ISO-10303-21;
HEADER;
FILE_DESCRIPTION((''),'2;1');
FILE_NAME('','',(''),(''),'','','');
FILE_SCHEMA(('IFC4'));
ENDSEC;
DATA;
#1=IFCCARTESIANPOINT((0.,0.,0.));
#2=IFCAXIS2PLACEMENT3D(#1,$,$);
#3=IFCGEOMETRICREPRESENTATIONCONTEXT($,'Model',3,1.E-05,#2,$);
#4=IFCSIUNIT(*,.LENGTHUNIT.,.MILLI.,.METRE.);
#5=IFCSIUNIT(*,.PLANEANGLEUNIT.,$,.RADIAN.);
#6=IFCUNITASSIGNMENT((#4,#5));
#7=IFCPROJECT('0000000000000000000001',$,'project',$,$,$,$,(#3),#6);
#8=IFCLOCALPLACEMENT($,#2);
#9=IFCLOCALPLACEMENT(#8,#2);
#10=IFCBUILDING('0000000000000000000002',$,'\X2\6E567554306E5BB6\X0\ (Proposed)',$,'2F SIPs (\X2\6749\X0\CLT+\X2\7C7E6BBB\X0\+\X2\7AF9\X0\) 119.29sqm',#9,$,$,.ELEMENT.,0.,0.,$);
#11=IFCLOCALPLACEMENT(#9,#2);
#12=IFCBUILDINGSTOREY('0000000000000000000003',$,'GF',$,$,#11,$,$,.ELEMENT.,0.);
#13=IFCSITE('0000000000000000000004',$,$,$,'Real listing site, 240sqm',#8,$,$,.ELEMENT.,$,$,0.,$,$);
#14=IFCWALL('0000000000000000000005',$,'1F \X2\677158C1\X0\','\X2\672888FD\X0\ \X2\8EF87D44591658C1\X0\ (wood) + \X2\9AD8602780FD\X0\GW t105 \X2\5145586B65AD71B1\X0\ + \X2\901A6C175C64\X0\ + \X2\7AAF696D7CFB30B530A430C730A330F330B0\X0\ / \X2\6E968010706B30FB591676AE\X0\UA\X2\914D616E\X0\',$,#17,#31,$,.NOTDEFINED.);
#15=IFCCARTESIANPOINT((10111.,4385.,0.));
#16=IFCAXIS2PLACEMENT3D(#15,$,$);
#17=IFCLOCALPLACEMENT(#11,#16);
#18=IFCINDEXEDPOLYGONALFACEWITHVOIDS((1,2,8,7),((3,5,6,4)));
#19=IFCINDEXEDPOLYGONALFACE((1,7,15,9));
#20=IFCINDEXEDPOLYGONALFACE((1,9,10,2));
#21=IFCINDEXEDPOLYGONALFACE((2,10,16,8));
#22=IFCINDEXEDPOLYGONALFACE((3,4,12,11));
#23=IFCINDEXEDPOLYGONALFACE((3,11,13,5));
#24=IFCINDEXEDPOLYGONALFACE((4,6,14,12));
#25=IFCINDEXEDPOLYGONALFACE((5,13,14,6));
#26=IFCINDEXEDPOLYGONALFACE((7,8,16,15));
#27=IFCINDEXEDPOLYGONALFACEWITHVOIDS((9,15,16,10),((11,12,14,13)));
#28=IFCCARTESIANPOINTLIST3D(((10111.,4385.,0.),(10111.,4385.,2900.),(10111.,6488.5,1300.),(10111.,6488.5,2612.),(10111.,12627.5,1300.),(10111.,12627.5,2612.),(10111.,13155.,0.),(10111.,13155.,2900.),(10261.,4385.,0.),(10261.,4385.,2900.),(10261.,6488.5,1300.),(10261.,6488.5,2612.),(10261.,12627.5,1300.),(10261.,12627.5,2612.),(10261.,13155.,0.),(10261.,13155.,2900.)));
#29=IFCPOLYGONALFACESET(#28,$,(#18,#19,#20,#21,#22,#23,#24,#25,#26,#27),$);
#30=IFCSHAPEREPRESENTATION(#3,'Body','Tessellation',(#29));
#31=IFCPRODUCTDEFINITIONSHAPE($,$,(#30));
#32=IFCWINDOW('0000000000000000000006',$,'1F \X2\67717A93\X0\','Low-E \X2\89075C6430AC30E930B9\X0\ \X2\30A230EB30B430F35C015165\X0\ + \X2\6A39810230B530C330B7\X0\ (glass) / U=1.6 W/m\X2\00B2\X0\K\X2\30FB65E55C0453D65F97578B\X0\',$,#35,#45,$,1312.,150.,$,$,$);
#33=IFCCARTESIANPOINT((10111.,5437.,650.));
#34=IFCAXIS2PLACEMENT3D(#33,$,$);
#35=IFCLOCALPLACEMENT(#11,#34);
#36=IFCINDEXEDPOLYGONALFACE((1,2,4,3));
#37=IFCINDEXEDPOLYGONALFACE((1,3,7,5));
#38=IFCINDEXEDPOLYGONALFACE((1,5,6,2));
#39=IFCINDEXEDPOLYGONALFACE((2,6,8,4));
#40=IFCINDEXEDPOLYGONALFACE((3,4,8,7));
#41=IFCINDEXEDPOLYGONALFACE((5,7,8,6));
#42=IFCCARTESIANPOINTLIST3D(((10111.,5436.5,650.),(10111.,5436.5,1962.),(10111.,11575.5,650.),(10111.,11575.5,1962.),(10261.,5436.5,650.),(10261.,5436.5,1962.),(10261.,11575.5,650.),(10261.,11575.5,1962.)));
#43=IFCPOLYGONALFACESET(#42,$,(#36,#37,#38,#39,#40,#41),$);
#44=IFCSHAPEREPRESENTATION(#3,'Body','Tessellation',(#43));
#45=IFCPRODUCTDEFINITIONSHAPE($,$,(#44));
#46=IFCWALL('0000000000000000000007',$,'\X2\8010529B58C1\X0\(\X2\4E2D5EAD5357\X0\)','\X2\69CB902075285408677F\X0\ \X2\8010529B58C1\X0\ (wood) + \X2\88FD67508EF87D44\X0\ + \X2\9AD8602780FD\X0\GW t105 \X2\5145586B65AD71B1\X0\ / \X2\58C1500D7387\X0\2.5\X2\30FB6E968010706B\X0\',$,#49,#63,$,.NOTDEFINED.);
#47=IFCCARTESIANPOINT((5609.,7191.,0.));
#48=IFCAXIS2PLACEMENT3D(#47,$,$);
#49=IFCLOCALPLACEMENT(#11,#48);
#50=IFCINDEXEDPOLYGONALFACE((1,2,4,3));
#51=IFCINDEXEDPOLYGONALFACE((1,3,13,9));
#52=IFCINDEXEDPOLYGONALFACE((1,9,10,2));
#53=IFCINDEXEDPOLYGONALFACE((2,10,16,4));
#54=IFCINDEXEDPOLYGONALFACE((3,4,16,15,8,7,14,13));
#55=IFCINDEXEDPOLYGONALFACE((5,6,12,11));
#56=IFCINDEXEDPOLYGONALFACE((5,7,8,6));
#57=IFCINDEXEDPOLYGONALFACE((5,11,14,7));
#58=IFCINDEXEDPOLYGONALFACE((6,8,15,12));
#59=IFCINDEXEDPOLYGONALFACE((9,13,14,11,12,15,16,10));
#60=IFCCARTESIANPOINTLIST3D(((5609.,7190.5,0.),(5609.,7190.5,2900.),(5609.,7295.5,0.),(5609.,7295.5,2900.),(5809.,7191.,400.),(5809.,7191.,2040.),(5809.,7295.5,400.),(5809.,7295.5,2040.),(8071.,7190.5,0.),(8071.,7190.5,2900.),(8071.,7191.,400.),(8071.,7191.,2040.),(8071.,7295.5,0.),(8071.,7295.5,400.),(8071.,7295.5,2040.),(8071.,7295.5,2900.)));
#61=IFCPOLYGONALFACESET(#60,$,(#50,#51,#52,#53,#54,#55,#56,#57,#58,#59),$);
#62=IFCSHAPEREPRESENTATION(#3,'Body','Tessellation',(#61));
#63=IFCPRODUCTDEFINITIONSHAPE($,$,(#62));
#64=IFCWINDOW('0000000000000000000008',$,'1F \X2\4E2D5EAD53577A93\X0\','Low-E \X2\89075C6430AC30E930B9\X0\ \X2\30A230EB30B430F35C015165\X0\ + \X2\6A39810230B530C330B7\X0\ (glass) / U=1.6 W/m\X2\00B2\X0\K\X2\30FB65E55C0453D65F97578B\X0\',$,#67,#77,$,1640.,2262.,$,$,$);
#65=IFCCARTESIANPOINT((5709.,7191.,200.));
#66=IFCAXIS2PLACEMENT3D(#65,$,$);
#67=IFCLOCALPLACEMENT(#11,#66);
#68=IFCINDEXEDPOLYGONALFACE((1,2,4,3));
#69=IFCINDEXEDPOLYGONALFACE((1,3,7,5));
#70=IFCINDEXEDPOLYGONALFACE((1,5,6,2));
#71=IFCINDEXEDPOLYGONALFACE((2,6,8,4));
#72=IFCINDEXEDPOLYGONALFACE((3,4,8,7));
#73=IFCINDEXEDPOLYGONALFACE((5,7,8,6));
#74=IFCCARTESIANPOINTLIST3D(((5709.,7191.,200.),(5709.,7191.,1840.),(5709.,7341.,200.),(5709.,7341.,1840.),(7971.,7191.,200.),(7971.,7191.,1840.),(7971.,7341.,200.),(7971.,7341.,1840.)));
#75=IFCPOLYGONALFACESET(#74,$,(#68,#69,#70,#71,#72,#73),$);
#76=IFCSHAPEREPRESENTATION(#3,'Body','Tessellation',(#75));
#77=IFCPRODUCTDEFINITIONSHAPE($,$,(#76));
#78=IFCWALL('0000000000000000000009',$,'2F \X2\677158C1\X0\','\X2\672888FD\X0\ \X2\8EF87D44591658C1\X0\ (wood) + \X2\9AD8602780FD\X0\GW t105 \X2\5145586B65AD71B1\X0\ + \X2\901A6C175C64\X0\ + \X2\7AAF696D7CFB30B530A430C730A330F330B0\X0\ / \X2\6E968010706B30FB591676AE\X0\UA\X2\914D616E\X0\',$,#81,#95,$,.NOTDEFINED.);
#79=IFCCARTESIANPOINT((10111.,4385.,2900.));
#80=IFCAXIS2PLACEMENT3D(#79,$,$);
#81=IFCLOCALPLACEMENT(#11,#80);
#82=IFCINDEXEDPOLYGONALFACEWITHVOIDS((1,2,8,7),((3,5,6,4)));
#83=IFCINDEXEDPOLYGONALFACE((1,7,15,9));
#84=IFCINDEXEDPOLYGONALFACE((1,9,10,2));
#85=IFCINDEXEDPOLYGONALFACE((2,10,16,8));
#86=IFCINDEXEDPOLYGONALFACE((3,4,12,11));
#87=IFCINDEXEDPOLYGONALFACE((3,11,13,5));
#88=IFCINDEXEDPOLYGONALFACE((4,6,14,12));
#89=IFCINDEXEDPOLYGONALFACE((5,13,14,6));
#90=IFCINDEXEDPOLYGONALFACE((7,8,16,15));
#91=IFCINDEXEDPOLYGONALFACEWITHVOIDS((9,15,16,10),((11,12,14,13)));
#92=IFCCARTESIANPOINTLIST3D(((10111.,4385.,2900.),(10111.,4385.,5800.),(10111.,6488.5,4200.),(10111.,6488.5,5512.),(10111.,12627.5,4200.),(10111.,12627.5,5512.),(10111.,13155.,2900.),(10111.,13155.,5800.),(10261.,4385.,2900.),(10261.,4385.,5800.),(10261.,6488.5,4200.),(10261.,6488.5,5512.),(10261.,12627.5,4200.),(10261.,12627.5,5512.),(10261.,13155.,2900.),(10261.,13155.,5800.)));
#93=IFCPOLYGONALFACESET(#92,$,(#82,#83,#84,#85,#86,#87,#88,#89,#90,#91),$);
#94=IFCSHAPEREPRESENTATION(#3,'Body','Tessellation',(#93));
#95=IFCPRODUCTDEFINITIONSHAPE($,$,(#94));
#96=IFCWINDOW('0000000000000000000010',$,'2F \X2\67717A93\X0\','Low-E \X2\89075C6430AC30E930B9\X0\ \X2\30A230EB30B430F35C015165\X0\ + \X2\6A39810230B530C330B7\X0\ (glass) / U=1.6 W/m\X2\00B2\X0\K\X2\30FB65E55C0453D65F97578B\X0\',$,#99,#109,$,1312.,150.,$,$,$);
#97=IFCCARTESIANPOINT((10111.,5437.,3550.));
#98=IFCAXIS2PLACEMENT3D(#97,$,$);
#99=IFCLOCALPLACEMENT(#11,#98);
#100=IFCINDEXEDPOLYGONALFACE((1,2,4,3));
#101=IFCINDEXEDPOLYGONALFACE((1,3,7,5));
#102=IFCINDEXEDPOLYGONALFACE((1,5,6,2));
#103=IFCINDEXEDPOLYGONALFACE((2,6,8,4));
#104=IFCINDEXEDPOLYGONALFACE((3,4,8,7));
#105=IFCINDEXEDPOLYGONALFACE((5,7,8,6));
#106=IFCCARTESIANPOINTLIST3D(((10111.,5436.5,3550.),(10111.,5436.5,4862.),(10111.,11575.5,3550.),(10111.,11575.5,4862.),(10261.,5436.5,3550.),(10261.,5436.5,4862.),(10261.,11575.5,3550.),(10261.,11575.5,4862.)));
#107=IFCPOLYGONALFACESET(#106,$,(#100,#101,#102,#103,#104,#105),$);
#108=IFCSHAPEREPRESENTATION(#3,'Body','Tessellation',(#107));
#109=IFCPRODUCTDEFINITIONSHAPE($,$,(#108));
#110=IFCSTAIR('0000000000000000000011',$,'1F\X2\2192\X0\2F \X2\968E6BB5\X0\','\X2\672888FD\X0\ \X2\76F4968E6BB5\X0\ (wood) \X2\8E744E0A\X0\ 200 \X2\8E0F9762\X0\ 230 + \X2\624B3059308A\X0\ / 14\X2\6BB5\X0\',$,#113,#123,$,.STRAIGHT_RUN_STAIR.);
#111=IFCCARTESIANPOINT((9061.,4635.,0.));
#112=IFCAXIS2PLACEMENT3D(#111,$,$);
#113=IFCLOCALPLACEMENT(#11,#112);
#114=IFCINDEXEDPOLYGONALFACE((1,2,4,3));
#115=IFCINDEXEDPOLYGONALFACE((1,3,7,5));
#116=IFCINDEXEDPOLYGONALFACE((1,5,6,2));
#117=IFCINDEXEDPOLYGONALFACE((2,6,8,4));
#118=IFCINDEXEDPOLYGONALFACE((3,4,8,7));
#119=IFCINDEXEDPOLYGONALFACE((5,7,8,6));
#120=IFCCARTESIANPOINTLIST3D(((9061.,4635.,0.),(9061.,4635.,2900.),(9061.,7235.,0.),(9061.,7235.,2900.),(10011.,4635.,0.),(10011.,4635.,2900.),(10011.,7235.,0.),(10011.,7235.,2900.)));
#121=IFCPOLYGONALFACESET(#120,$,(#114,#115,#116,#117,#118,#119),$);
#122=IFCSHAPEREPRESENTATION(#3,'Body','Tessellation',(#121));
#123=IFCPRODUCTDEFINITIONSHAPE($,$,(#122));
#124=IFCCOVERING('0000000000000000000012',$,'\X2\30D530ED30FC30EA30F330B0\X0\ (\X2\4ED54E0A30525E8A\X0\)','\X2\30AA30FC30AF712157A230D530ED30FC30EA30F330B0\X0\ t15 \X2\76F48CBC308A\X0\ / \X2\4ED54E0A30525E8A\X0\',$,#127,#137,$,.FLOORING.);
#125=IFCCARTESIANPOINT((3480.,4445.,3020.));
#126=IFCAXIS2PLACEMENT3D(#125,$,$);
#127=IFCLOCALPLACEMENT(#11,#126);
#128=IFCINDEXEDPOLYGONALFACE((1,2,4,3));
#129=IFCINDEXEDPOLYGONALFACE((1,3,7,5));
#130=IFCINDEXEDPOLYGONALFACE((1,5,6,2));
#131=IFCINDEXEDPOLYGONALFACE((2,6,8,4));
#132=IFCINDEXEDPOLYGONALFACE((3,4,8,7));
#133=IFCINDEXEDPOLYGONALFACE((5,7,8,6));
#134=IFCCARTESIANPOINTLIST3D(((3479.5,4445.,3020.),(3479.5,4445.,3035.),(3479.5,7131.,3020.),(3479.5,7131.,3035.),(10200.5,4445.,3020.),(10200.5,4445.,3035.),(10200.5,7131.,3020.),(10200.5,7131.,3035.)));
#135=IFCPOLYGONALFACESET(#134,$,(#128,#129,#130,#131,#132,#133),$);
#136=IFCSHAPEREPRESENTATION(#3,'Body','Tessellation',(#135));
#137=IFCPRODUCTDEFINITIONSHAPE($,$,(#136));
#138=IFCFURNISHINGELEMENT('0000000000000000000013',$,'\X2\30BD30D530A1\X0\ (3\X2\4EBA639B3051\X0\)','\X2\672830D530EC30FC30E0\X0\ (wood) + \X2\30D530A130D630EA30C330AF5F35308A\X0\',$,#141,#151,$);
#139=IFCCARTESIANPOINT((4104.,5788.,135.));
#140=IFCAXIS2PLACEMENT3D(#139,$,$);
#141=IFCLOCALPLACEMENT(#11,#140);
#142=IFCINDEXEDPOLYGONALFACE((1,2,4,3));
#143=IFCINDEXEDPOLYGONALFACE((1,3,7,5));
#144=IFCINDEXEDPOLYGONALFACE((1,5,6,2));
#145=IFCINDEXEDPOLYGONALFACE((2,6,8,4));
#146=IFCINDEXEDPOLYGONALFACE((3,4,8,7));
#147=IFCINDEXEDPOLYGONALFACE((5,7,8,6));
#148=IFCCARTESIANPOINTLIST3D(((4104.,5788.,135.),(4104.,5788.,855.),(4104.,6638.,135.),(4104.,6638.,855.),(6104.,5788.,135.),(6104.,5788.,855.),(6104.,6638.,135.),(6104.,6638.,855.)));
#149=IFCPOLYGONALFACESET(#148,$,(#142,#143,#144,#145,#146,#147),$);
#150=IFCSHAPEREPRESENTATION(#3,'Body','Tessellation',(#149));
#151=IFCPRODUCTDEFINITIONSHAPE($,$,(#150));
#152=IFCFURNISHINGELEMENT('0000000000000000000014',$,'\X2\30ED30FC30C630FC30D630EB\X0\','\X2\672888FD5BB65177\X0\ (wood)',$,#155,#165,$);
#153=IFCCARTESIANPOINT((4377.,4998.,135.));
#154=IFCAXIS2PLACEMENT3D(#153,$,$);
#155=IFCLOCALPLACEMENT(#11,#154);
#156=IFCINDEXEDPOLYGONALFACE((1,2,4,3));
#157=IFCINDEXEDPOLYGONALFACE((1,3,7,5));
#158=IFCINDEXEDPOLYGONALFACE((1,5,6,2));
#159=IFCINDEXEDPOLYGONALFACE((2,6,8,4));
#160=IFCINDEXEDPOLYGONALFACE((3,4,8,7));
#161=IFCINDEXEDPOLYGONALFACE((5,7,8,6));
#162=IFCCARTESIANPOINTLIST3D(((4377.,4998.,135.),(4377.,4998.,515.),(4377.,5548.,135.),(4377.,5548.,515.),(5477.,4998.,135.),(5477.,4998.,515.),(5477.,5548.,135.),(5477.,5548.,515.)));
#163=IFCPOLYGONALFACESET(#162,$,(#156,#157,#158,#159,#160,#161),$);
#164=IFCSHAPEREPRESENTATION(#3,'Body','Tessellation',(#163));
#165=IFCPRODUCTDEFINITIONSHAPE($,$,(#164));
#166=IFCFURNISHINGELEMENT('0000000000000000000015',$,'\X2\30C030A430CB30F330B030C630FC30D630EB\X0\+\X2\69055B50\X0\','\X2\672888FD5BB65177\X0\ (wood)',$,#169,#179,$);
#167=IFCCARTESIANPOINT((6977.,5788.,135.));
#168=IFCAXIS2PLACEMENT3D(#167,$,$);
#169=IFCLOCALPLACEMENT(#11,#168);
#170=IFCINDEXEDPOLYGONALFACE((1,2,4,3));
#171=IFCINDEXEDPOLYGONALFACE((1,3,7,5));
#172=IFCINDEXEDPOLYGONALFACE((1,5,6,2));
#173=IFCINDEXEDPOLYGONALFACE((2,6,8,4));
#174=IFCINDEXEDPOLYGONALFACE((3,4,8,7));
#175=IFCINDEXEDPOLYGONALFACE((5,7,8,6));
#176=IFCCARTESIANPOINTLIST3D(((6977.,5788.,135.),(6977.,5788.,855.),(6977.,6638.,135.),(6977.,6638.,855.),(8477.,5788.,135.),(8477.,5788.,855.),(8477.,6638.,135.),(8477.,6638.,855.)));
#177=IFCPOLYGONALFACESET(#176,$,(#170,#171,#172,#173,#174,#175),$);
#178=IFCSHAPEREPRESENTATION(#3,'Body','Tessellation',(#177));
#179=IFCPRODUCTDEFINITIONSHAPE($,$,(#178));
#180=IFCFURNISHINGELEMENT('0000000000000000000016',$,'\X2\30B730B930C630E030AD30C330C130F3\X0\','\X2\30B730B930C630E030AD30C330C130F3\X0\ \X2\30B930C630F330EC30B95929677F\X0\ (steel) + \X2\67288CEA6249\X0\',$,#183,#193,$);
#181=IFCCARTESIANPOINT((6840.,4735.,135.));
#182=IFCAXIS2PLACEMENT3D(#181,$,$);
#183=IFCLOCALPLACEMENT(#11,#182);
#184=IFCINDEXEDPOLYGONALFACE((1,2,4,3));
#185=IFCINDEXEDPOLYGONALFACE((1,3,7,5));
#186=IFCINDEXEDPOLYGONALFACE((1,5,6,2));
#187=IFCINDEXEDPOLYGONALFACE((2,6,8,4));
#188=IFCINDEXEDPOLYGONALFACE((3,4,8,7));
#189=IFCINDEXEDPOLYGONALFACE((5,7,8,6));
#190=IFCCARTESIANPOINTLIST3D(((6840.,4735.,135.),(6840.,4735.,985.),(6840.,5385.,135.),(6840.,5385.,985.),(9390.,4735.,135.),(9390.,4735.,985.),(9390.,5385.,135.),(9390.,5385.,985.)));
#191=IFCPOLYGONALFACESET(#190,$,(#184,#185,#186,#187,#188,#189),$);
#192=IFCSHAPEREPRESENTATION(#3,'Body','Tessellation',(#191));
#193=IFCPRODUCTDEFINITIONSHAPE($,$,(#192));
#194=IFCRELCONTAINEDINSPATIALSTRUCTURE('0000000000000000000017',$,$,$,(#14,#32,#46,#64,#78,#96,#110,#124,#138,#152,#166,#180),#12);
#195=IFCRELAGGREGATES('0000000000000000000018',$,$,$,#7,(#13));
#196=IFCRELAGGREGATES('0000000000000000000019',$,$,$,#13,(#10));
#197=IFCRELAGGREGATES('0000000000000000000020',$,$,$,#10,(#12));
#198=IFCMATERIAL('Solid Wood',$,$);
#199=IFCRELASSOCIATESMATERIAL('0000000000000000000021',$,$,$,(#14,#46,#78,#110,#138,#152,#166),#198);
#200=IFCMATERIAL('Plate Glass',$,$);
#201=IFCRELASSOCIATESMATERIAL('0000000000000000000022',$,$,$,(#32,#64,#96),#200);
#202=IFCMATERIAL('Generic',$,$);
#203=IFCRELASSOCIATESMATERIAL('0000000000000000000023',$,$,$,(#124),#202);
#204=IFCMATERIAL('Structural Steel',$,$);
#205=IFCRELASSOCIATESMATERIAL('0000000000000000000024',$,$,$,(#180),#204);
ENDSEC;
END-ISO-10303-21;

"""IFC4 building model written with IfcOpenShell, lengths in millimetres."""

from ifc_helpers import new_model, si_unit, frame, frame_2d, origin, place, context, project, spatial, rectangle, extrude, material, element, fill, save


model = new_model("IFC4")

# Units and contexts
model_context = context("Model", 3, precision=1e-05, world=origin())
ifc_project = project(units=[si_unit("LENGTHUNIT", "METRE", prefix="MILLI"), si_unit("PLANEANGLEUNIT", "RADIAN")], contexts=[model_context])

# Site, building, storey
site_placement = place(None, origin())
site = spatial("IfcSite", under=ifc_project, at=site_placement, ObjectType="Real listing site, 240sqm", CompositionType="ELEMENT", RefElevation=0.0)
building_placement = place(site_placement, origin())
building = spatial("IfcBuilding", under=site, at=building_placement, Name="湖畔の家 (Proposed)", ObjectType="2F SIPs (杉CLT+籾殻+竹) 119.29sqm", CompositionType="ELEMENT", ElevationOfRefHeight=0.0, ElevationOfTerrain=0.0)
storey_placement = place(building_placement, origin())
storey = spatial("IfcBuildingStorey", under=building, at=storey_placement, Name="GF", CompositionType="ELEMENT", Elevation=0.0)

# Shared definitions
ifc_material_1 = material(Name="Solid Wood")

# Walls, openings, windows
wall_1_placement = place(storey_placement, frame((10111.0, 4385.0, 0.0)))
wall_1 = element("IfcWall", 1, at=wall_1_placement, inside=storey, material=ifc_material_1, Name="1F 東壁", Description="木製 軸組外壁 (wood) + 高性能GW t105 充填断熱 + 通気層 + 窯業系サイディング / 準耐火・外皮UA配慮", PredefinedType="NOTDEFINED", context=model_context, shape_type="SweptSolid", body=[
    extrude(rectangle(XDim=150.0, YDim=8770.0, at=frame_2d((75.0, 4385.0))), frame((10111.0, 4385.0, 0.0)), (0.0, 0.0, 1.0), 2900.0),
])
opening_1_placement = place(storey_placement, frame((10111.0, 5437.0, 650.0)))
opening_1 = element("IfcOpeningElement", 2, at=opening_1_placement, cuts=wall_1, PredefinedType="NOTDEFINED", context=model_context, shape_type="SweptSolid", body=[
    extrude(rectangle(XDim=150.0, YDim=6139.0, at=frame_2d((75.0, 3069.0))), frame((10111.0, 5437.0, 650.0)), (0.0, 0.0, 1.0), 1312.0),
])
ifc_material_2 = material(Name="Plate Glass")
window_1_placement = place(storey_placement, frame((10111.0, 5437.0, 650.0)))
window_1 = element("IfcWindow", 3, at=window_1_placement, inside=storey, material=ifc_material_2, Name="1F 東窓", Description="Low-E 複層ガラス アルゴン封入 + 樹脂サッシ (glass) / U=1.6 W/m²K・日射取得型", OverallHeight=1312.0, OverallWidth=150.0, context=model_context, shape_type="SweptSolid", body=[
    extrude(rectangle(XDim=150.0, YDim=6139.0, at=frame_2d((75.0, 3069.0))), frame((10111.0, 5437.0, 650.0)), (0.0, 0.0, 1.0), 1312.0),
])
fill(opening_1, window_1)
wall_2_placement = place(storey_placement, frame((5609.0, 7191.0, 0.0)))
wall_2 = element("IfcWall", 4, at=wall_2_placement, inside=storey, material=ifc_material_1, Name="耐力壁(中庭南)", Description="構造用合板 耐力壁 (wood) + 製材軸組 + 高性能GW t105 充填断熱 / 壁倍率2.5・準耐火", PredefinedType="NOTDEFINED", context=model_context, shape_type="SweptSolid", body=[
    extrude(rectangle(XDim=2462.0, YDim=105.0, at=frame_2d((1231.0, 52.0))), frame((5609.0, 7191.0, 0.0)), (0.0, 0.0, 1.0), 2900.0),
])
opening_2_placement = place(storey_placement, frame((5709.0, 7191.0, 200.0)))
opening_2 = element("IfcOpeningElement", 5, at=opening_2_placement, cuts=wall_2, PredefinedType="NOTDEFINED", context=model_context, shape_type="SweptSolid", body=[
    extrude(rectangle(XDim=2262.0, YDim=150.0, at=frame_2d((1131.0, 75.0))), frame((5709.0, 7191.0, 200.0)), (0.0, 0.0, 1.0), 1640.0),
])
window_2_placement = place(storey_placement, frame((5709.0, 7191.0, 200.0)))
window_2 = element("IfcWindow", 6, at=window_2_placement, inside=storey, material=ifc_material_2, Name="1F 中庭南窓", Description="Low-E 複層ガラス アルゴン封入 + 樹脂サッシ (glass) / U=1.6 W/m²K・日射取得型", OverallHeight=1640.0, OverallWidth=2262.0, context=model_context, shape_type="SweptSolid", body=[
    extrude(rectangle(XDim=2262.0, YDim=150.0, at=frame_2d((1131.0, 75.0))), frame((5709.0, 7191.0, 200.0)), (0.0, 0.0, 1.0), 1640.0),
])
fill(opening_2, window_2)

# Wall, opening, window
wall_3_placement = place(storey_placement, frame((10111.0, 4385.0, 2900.0)))
wall_3 = element("IfcWall", 7, at=wall_3_placement, inside=storey, material=ifc_material_1, Name="2F 東壁", Description="木製 軸組外壁 (wood) + 高性能GW t105 充填断熱 + 通気層 + 窯業系サイディング / 準耐火・外皮UA配慮", PredefinedType="NOTDEFINED", context=model_context, shape_type="SweptSolid", body=[
    extrude(rectangle(XDim=150.0, YDim=8770.0, at=frame_2d((75.0, 4385.0))), frame((10111.0, 4385.0, 2900.0)), (0.0, 0.0, 1.0), 2900.0),
])
opening_3_placement = place(storey_placement, frame((10111.0, 5437.0, 3550.0)))
opening_3 = element("IfcOpeningElement", 8, at=opening_3_placement, cuts=wall_3, PredefinedType="NOTDEFINED", context=model_context, shape_type="SweptSolid", body=[
    extrude(rectangle(XDim=150.0, YDim=6139.0, at=frame_2d((75.0, 3069.0))), frame((10111.0, 5437.0, 3550.0)), (0.0, 0.0, 1.0), 1312.0),
])
window_3_placement = place(storey_placement, frame((10111.0, 5437.0, 3550.0)))
window_3 = element("IfcWindow", 9, at=window_3_placement, inside=storey, material=ifc_material_2, Name="2F 東窓", Description="Low-E 複層ガラス アルゴン封入 + 樹脂サッシ (glass) / U=1.6 W/m²K・日射取得型", OverallHeight=1312.0, OverallWidth=150.0, context=model_context, shape_type="SweptSolid", body=[
    extrude(rectangle(XDim=150.0, YDim=6139.0, at=frame_2d((75.0, 3069.0))), frame((10111.0, 5437.0, 3550.0)), (0.0, 0.0, 1.0), 1312.0),
])
fill(opening_3, window_3)

# Stair
stair_placement = place(storey_placement, frame((9061.0, 4635.0, 0.0)))
element("IfcStair", 10, at=stair_placement, inside=storey, material=ifc_material_1, Name="1F→2F 階段", Description="木製 直階段 (wood) 蹴上 200 踏面 230 + 手すり / 14段", PredefinedType="STRAIGHT_RUN_STAIR", context=model_context, shape_type="SweptSolid", body=[
    extrude(rectangle(XDim=950.0, YDim=2600.0, at=frame_2d((475.0, 1300.0))), frame((9061.0, 4635.0, 0.0)), (0.0, 0.0, 1.0), 2900.0),
])

# Covering
ifc_material_3 = material(Name="Generic")
covering_placement = place(storey_placement, frame((3480.0, 4445.0, 3020.0)))
element("IfcCovering", 11, at=covering_placement, inside=storey, material=ifc_material_3, Name="フローリング (仕上げ床)", Description="オーク無垢フローリング t15 直貼り / 仕上げ床", PredefinedType="FLOORING", context=model_context, shape_type="SweptSolid", body=[
    extrude(rectangle(XDim=6721.0, YDim=2686.0, at=frame_2d((3360.0, 1343.0))), frame((3480.0, 4445.0, 3020.0)), (0.0, 0.0, 1.0), 15.0),
])

# Furnishing elements
furnishing_1_placement = place(storey_placement, frame((4104.0, 5788.0, 135.0)))
element("IfcFurnishingElement", 12, at=furnishing_1_placement, inside=storey, material=ifc_material_1, Name="ソファ (3人掛け)", Description="木フレーム (wood) + ファブリック張り", context=model_context, shape_type="SweptSolid", body=[
    extrude(rectangle(XDim=2000.0, YDim=850.0, at=frame_2d((1000.0, 425.0))), frame((4104.0, 5788.0, 135.0)), (0.0, 0.0, 1.0), 720.0),
])
furnishing_2_placement = place(storey_placement, frame((4377.0, 4998.0, 135.0)))
element("IfcFurnishingElement", 13, at=furnishing_2_placement, inside=storey, material=ifc_material_1, Name="ローテーブル", Description="木製家具 (wood)", context=model_context, shape_type="SweptSolid", body=[
    extrude(rectangle(XDim=1100.0, YDim=550.0, at=frame_2d((550.0, 275.0))), frame((4377.0, 4998.0, 135.0)), (0.0, 0.0, 1.0), 380.0),
])
furnishing_3_placement = place(storey_placement, frame((6977.0, 5788.0, 135.0)))
element("IfcFurnishingElement", 14, at=furnishing_3_placement, inside=storey, material=ifc_material_1, Name="ダイニングテーブル+椅子", Description="木製家具 (wood)", context=model_context, shape_type="SweptSolid", body=[
    extrude(rectangle(XDim=1500.0, YDim=850.0, at=frame_2d((750.0, 425.0))), frame((6977.0, 5788.0, 135.0)), (0.0, 0.0, 1.0), 720.0),
])
ifc_material_4 = material(Name="Structural Steel")
furnishing_4_placement = place(storey_placement, frame((6840.0, 4735.0, 135.0)))
element("IfcFurnishingElement", 15, at=furnishing_4_placement, inside=storey, material=ifc_material_4, Name="システムキッチン", Description="システムキッチン ステンレス天板 (steel) + 木質扉", context=model_context, shape_type="SweptSolid", body=[
    extrude(rectangle(XDim=2550.0, YDim=650.0, at=frame_2d((1275.0, 325.0))), frame((6840.0, 4735.0, 135.0)), (0.0, 0.0, 1.0), 850.0),
])

save(model, "model.ifc")
